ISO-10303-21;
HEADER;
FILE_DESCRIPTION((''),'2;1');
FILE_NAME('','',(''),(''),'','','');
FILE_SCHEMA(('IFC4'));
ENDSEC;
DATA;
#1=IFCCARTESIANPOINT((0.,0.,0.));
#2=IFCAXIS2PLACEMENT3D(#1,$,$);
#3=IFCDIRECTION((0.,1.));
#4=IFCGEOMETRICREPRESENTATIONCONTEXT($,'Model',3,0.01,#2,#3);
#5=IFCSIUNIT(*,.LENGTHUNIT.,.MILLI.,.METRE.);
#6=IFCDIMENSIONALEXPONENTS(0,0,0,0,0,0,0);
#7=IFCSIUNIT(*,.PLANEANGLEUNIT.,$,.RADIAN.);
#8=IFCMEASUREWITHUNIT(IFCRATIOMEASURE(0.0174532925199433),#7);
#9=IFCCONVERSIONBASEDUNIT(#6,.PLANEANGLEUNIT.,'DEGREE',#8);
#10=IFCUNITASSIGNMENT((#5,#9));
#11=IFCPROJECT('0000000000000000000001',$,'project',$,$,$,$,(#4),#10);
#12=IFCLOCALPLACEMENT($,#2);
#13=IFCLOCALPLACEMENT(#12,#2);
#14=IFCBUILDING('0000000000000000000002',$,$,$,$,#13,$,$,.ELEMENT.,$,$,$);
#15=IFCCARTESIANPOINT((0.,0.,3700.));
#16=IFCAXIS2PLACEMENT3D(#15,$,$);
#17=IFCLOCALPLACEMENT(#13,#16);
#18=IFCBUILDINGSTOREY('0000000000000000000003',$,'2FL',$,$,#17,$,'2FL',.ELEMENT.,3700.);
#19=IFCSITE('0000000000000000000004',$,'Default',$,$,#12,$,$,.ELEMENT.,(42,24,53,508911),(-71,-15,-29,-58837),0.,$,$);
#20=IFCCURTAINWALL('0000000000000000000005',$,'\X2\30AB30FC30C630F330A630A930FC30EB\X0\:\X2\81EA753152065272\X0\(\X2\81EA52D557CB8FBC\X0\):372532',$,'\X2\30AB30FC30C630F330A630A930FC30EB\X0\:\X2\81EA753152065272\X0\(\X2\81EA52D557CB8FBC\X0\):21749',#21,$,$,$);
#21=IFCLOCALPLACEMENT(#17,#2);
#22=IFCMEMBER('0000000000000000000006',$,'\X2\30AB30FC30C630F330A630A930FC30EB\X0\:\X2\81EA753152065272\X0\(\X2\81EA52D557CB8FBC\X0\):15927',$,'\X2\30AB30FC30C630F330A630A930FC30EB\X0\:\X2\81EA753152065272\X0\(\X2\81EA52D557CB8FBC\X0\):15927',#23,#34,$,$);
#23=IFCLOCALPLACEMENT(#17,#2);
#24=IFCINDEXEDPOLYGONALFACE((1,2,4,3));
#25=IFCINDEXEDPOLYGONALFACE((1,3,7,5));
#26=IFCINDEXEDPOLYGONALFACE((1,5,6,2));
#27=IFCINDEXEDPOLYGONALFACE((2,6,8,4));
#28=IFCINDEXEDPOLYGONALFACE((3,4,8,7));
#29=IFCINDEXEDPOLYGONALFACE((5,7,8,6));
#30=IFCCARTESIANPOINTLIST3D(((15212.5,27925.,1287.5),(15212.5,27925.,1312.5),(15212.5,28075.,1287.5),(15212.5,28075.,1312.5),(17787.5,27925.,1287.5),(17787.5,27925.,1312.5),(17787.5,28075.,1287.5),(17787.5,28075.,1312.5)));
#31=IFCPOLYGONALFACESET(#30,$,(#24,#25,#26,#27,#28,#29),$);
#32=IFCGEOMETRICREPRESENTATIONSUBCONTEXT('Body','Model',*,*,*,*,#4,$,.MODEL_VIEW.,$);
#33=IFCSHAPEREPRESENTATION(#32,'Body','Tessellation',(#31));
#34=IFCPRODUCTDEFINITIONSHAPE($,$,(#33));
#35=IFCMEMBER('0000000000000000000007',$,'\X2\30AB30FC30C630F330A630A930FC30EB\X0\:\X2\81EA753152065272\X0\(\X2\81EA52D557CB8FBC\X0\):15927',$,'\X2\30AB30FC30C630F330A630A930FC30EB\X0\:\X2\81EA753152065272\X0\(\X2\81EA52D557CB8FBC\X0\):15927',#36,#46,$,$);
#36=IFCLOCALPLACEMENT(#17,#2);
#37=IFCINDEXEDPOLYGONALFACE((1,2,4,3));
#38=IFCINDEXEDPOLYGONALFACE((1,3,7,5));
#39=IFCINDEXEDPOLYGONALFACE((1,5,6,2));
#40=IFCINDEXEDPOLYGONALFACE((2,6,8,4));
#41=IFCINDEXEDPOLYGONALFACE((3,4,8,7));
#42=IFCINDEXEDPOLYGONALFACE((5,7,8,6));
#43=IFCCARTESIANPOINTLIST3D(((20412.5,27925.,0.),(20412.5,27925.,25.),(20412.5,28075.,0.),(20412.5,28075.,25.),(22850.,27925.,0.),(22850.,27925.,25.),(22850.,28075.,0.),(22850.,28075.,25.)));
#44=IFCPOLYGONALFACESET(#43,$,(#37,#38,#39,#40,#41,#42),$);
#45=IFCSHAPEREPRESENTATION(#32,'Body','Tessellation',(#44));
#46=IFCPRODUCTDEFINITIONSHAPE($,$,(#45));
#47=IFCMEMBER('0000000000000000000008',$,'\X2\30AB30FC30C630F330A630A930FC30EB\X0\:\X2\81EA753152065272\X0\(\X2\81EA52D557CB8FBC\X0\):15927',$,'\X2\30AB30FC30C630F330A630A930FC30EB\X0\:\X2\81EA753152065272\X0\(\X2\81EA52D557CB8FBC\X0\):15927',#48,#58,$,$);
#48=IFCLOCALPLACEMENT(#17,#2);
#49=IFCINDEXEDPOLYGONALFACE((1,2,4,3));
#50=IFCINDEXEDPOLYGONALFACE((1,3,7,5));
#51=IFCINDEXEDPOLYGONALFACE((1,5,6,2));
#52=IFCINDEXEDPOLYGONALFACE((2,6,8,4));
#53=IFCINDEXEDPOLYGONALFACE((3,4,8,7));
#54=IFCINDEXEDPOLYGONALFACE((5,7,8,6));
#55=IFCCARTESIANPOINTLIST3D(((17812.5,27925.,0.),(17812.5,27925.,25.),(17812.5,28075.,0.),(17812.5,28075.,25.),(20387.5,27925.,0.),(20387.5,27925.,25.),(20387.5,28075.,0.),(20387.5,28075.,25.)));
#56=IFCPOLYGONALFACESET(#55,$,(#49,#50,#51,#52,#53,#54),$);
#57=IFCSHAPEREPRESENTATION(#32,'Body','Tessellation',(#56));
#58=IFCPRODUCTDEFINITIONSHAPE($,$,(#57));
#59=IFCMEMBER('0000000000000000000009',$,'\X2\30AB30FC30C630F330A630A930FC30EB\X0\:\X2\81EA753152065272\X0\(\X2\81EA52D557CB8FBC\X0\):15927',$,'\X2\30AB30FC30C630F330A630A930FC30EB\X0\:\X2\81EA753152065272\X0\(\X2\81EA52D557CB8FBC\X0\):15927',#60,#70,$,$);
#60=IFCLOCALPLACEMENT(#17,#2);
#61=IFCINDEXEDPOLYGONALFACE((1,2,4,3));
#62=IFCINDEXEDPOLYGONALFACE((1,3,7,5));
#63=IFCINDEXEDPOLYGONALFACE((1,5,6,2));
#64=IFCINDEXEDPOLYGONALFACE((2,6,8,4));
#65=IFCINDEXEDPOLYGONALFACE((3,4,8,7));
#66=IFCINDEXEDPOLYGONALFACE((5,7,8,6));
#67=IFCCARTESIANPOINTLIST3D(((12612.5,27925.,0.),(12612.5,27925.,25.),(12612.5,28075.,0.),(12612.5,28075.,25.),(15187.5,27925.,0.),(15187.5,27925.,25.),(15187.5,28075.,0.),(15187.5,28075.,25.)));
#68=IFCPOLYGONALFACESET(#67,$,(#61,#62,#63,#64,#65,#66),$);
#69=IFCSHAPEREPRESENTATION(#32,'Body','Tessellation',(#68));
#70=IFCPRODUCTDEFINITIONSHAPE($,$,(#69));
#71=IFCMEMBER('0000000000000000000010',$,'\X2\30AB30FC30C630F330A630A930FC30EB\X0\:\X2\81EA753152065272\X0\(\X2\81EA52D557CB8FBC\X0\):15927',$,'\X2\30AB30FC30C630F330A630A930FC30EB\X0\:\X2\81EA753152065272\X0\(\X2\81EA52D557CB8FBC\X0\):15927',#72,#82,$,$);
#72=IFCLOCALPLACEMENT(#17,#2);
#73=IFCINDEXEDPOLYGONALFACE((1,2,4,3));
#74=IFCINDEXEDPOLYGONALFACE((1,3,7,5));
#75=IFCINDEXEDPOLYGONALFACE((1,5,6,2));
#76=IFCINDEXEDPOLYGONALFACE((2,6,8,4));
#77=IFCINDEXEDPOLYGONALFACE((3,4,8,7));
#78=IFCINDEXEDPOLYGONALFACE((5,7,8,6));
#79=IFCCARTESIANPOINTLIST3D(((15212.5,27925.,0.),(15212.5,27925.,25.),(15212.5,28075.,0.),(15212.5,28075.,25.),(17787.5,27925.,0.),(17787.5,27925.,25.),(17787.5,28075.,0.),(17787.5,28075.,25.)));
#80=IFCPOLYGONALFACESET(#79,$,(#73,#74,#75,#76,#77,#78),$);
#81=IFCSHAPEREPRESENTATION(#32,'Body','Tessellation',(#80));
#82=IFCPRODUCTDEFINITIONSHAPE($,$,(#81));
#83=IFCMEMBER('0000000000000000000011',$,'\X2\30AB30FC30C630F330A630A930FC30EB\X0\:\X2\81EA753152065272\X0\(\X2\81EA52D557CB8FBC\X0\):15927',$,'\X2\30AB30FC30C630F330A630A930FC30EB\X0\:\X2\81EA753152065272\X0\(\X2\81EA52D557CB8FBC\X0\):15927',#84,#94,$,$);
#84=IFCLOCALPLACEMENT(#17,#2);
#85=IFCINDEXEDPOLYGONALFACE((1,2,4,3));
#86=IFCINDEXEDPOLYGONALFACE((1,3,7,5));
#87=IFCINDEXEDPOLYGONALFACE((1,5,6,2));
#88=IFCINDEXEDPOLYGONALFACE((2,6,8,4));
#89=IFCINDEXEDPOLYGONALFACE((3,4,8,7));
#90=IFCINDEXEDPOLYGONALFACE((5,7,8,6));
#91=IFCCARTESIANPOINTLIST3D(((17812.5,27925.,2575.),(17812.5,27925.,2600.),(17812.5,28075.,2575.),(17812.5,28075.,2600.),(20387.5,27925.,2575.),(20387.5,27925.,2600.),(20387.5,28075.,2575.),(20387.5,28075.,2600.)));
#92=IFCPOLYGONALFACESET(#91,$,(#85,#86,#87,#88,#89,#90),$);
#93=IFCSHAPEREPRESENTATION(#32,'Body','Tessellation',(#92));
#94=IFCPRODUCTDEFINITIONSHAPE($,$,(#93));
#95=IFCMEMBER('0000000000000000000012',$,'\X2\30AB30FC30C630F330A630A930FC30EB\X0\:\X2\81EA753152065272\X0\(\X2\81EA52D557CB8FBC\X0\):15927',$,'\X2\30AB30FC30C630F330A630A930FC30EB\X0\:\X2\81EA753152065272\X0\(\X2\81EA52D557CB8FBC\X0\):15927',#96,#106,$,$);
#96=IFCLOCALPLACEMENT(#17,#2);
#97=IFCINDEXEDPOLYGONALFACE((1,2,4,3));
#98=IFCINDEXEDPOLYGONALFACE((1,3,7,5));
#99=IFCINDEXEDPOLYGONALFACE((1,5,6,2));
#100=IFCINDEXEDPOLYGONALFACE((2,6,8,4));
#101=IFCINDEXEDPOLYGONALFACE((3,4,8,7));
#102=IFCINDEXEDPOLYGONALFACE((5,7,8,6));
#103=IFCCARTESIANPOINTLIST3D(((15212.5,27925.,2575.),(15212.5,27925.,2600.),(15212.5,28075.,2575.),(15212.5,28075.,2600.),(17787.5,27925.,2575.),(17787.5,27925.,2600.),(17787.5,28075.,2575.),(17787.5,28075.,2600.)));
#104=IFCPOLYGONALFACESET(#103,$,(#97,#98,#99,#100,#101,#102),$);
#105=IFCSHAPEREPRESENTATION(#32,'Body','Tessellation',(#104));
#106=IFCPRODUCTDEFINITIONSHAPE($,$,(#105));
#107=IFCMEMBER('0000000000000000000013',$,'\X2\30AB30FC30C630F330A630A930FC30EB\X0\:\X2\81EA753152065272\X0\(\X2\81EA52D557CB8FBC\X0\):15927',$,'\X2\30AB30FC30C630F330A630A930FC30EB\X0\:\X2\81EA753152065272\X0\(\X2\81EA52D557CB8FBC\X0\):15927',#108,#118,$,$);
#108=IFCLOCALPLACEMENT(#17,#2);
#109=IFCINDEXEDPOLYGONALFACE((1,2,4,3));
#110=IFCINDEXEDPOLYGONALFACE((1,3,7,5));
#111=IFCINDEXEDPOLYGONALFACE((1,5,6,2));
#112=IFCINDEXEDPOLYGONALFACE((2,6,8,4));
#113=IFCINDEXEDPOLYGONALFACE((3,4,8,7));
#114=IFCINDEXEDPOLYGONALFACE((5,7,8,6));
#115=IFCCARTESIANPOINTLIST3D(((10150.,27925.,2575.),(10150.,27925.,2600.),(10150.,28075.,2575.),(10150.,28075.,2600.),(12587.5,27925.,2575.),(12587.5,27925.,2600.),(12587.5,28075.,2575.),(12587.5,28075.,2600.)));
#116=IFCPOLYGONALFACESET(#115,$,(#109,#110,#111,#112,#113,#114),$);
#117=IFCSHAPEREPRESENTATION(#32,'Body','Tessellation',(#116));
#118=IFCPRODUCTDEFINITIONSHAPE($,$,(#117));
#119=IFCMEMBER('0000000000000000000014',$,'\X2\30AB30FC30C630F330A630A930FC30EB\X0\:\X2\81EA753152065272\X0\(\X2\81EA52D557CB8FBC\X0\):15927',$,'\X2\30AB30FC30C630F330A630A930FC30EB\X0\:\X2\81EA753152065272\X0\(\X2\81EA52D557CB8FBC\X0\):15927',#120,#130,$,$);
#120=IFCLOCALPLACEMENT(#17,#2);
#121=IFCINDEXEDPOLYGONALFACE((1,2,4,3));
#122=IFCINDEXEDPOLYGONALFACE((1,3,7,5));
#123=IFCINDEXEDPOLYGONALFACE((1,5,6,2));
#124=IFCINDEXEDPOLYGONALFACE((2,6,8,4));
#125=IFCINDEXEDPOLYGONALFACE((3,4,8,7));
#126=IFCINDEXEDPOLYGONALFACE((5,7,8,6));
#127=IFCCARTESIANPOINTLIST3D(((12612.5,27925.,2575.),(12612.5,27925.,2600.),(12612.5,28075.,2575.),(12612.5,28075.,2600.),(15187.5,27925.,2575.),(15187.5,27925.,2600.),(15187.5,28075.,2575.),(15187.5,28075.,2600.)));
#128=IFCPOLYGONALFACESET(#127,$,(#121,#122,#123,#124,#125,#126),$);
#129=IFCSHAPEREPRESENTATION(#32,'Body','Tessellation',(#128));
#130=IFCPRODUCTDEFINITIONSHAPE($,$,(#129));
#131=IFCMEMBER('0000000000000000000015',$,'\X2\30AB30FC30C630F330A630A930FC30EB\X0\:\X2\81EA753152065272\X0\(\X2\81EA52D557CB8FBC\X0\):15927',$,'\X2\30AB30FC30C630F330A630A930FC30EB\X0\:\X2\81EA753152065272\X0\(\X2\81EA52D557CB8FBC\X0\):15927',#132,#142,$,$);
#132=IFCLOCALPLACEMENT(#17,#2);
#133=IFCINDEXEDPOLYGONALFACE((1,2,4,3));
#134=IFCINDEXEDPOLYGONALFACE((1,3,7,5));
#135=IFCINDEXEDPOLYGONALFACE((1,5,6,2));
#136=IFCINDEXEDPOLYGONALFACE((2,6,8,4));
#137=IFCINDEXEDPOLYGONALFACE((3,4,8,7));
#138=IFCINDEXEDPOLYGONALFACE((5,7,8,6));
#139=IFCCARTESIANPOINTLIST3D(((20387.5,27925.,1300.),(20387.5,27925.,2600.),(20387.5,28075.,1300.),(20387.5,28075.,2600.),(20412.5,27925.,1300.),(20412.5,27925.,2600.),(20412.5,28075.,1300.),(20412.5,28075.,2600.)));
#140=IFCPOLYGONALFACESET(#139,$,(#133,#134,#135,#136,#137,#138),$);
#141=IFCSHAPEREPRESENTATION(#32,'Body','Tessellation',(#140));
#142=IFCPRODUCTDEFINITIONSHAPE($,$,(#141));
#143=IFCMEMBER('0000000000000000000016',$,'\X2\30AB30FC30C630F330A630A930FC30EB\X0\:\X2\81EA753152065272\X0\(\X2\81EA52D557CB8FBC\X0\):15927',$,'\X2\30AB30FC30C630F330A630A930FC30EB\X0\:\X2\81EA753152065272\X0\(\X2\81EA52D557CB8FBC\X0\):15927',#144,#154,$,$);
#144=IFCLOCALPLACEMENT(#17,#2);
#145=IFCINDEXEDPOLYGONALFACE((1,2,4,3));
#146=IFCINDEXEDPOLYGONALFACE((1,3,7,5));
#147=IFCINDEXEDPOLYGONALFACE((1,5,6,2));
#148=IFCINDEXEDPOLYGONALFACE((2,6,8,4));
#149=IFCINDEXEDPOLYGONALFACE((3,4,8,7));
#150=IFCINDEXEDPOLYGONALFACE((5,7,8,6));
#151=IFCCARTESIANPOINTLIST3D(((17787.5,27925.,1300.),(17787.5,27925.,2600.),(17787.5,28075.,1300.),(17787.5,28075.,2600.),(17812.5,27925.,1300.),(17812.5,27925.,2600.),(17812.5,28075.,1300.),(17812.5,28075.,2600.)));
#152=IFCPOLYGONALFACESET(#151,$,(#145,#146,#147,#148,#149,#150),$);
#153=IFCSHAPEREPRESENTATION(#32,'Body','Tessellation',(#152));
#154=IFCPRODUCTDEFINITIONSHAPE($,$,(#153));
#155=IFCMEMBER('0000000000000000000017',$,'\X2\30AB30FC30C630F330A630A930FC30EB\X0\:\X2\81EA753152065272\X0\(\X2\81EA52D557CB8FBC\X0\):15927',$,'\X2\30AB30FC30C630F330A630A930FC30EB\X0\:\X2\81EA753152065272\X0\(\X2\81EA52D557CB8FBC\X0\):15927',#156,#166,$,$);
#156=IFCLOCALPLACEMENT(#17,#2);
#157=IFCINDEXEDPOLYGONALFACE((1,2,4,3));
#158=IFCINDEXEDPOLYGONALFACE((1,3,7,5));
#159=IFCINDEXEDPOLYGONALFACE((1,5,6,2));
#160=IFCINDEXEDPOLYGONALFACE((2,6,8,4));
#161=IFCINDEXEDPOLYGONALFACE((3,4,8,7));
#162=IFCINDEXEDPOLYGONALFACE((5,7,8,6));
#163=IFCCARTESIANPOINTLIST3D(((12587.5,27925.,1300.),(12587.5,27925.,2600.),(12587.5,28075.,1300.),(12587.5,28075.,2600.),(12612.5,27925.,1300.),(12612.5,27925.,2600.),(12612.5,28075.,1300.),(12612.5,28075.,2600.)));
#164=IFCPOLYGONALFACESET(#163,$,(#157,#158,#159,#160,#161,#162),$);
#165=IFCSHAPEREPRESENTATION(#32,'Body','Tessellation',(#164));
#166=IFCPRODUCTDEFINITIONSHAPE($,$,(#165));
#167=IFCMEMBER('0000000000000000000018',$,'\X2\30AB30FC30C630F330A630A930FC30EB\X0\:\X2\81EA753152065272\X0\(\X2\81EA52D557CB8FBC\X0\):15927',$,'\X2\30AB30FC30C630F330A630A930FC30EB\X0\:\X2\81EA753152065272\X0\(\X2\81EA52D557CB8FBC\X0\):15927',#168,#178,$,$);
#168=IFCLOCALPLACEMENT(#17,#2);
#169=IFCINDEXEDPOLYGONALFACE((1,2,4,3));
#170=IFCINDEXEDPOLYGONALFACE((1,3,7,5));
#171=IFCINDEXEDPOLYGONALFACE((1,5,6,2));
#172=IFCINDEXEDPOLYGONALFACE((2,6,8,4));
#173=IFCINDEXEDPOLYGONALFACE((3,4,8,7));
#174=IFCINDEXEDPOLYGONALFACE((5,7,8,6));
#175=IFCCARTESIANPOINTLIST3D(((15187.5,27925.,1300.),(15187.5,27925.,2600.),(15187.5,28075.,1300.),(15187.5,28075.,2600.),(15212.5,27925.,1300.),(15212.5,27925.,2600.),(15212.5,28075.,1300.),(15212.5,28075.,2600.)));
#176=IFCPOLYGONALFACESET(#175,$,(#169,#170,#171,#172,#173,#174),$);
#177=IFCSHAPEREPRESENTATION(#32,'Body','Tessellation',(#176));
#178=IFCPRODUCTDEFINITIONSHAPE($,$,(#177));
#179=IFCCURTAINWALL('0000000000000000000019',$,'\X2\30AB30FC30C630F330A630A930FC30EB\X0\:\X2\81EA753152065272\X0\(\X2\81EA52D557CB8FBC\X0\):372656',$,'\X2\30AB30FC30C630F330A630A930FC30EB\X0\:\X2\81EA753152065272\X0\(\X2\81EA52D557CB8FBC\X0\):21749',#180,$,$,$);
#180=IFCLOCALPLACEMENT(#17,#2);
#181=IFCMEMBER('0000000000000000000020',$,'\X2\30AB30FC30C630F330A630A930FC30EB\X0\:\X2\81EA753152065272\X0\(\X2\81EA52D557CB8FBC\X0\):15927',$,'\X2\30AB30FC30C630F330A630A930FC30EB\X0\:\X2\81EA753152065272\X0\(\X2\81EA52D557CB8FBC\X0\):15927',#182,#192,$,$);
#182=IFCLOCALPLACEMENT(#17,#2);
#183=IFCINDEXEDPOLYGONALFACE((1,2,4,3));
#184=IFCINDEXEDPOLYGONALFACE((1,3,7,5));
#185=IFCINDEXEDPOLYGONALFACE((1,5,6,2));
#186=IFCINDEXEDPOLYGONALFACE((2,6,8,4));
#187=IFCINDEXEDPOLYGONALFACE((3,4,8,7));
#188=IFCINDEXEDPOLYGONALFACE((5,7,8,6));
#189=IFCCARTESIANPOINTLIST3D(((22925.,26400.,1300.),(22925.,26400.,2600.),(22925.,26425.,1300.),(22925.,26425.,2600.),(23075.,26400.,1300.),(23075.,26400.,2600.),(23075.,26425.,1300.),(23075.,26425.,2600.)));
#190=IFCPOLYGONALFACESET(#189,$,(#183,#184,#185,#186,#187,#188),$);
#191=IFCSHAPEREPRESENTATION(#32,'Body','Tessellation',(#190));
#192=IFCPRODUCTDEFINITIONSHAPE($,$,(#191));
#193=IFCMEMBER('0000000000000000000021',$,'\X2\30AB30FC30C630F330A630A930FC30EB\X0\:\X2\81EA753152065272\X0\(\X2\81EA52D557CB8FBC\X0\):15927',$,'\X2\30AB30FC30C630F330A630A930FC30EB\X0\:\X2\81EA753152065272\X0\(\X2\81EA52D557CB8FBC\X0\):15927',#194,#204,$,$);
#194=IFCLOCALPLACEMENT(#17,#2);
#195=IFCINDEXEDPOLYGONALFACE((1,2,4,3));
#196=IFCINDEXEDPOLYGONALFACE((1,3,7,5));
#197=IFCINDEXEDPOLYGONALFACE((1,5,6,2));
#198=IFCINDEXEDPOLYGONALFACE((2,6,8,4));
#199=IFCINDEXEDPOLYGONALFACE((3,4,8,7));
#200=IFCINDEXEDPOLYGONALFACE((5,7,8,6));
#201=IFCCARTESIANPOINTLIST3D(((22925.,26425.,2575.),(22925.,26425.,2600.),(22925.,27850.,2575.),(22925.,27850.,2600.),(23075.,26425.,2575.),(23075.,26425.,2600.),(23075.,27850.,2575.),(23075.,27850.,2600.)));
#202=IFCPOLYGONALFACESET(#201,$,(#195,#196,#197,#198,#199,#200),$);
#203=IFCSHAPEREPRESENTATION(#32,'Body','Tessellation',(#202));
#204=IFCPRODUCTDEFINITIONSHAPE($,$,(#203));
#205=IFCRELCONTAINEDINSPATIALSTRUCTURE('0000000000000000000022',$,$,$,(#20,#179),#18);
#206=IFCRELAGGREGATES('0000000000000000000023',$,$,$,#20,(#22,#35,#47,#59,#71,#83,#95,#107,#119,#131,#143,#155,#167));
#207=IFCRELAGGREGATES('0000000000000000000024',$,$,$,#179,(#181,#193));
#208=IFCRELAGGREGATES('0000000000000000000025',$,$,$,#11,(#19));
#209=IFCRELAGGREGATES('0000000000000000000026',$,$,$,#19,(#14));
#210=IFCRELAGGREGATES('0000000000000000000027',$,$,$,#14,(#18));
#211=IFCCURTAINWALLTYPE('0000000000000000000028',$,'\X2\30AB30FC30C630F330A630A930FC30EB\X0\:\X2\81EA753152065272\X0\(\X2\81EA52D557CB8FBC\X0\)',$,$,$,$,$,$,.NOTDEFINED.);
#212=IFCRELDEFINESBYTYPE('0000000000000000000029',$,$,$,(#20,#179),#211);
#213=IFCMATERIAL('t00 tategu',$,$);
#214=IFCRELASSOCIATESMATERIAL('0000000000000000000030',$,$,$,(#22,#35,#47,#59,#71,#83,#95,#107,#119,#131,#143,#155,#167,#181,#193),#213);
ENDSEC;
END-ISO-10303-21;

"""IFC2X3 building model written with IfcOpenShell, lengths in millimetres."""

from ifc_helpers import new_model, entity, si_unit, converted_unit, direction, frame, frame_2d, origin, origin_2d_with_axis, place, context, subcontext, project, spatial, rectangle, extrude, material, type_object, element, aggregate, save


model = new_model("IFC2X3")

# Units and contexts
model_context = context("Model", 3, precision=0.01, world=origin(), true_north=direction((0.0, 1.0)))
body_context = subcontext(model_context, "Body", "Model", "MODEL_VIEW")
ifc_project = project(units=[si_unit("LENGTHUNIT", "METRE", prefix="MILLI"), converted_unit("PLANEANGLEUNIT", "DEGREE", entity("IfcRatioMeasure", 0.0174532925199433), si_unit("PLANEANGLEUNIT", "RADIAN"), dimensions=[0, 0, 0, 0, 0, 0, 0])], contexts=[model_context])

# Site, building, storey
site_placement = place(None, origin())
site = spatial("IfcSite", under=ifc_project, at=site_placement, Name="Default", CompositionType="ELEMENT", RefLatitude=(42, 24, 53, 508911), RefLongitude=(-71, -15, -29, -58837), RefElevation=0.0)
building_placement = place(site_placement, origin())
building = spatial("IfcBuilding", under=site, at=building_placement, CompositionType="ELEMENT")
storey_placement = place(building_placement, frame((0.0, 0.0, 3700.0)))
storey = spatial("IfcBuildingStorey", under=building, at=storey_placement, Name="2FL", LongName="2FL", CompositionType="ELEMENT", Elevation=3700.0)

# Curtain walls, members
curtain_wall_type = type_object("IfcCurtainWallType", Name="カーテンウォール:自由分割(自動埋込)", PredefinedType="NOTDEFINED")
curtain_wall_1_placement = place(storey_placement, frame((0.0, 0.0, -3700.0)))
curtain_wall_1 = element("IfcCurtainWall", 1, at=curtain_wall_1_placement, inside=storey, type_object=curtain_wall_type, Name="カーテンウォール:自由分割(自動埋込):372532", ObjectType="カーテンウォール:自由分割(自動埋込):21749")
ifc_material = material(Name="t00 tategu")
member_1_placement = place(curtain_wall_1_placement, frame((0.0, 0.0, 3700.0)))
member_1 = element("IfcMember", 2, at=member_1_placement, material=ifc_material, Name="カーテンウォール:自由分割(自動埋込):15927", ObjectType="カーテンウォール:自由分割(自動埋込):15927", context=body_context, shape_type="SweptSolid", body=[
    extrude(rectangle(XDim=25.0, YDim=150.0, at=frame_2d((0.0, 0.0), x_axis=(1.0, 0.0))), frame((17787.5, 28000.0, 1300.0), z_axis=(-1.0, 0.0, 0.0), x_axis=(0.0, 0.0, -1.0)), (0.0, 0.0, 1.0), 2575.0),
])
member_2_placement = place(curtain_wall_1_placement, frame((0.0, 0.0, 3700.0)))
member_2 = element("IfcMember", 3, at=member_2_placement, material=ifc_material, Name="カーテンウォール:自由分割(自動埋込):15927", ObjectType="カーテンウォール:自由分割(自動埋込):15927", context=body_context, shape_type="SweptSolid", body=[
    extrude(rectangle(XDim=25.0, YDim=150.0, at=frame_2d((0.0, 0.0), x_axis=(1.0, 0.0))), frame((20412.5, 28000.0, 12.5), z_axis=(1.0, 0.0, 0.0), x_axis=(0.0, 0.0, -1.0)), (0.0, 0.0, 1.0), 2437.5),
])
member_3_placement = place(curtain_wall_1_placement, frame((0.0, 0.0, 3700.0)))
member_3 = element("IfcMember", 4, at=member_3_placement, material=ifc_material, Name="カーテンウォール:自由分割(自動埋込):15927", ObjectType="カーテンウォール:自由分割(自動埋込):15927", context=body_context, shape_type="SweptSolid", body=[
    extrude(rectangle(XDim=25.0, YDim=150.0, at=frame_2d((0.0, 0.0), x_axis=(1.0, 0.0))), frame((17812.5, 28000.0, 12.5), z_axis=(1.0, 0.0, 0.0), x_axis=(0.0, 0.0, -1.0)), (0.0, 0.0, 1.0), 2575.0),
])
member_4_placement = place(curtain_wall_1_placement, frame((0.0, 0.0, 3700.0)))
member_4 = element("IfcMember", 5, at=member_4_placement, material=ifc_material, Name="カーテンウォール:自由分割(自動埋込):15927", ObjectType="カーテンウォール:自由分割(自動埋込):15927", context=body_context, shape_type="SweptSolid", body=[
    extrude(rectangle(XDim=25.0, YDim=150.0, at=frame_2d((0.0, 0.0), x_axis=(1.0, 0.0))), frame((12612.5, 28000.0, 12.5), z_axis=(1.0, 0.0, 0.0), x_axis=(0.0, 0.0, -1.0)), (0.0, 0.0, 1.0), 2575.0),
])
member_5_placement = place(curtain_wall_1_placement, frame((0.0, 0.0, 3700.0)))
member_5 = element("IfcMember", 6, at=member_5_placement, material=ifc_material, Name="カーテンウォール:自由分割(自動埋込):15927", ObjectType="カーテンウォール:自由分割(自動埋込):15927", context=body_context, shape_type="SweptSolid", body=[
    extrude(rectangle(XDim=25.0, YDim=150.0, at=frame_2d((0.0, 0.0), x_axis=(1.0, 0.0))), frame((15212.5, 28000.0, 12.5), z_axis=(1.0, 0.0, 0.0), x_axis=(0.0, 0.0, -1.0)), (0.0, 0.0, 1.0), 2575.0),
])
member_6_placement = place(curtain_wall_1_placement, frame((0.0, 0.0, 3700.0)))
member_6 = element("IfcMember", 7, at=member_6_placement, material=ifc_material, Name="カーテンウォール:自由分割(自動埋込):15927", ObjectType="カーテンウォール:自由分割(自動埋込):15927", context=body_context, shape_type="SweptSolid", body=[
    extrude(rectangle(XDim=25.0, YDim=150.0, at=frame_2d((0.0, 0.0), x_axis=(1.0, 0.0))), frame((20387.5, 28000.0, 2587.5), z_axis=(-1.0, 0.0, 0.0), x_axis=(0.0, 0.0, -1.0)), (0.0, 0.0, 1.0), 2575.0),
])
member_7_placement = place(curtain_wall_1_placement, frame((0.0, 0.0, 3700.0)))
member_7 = element("IfcMember", 8, at=member_7_placement, material=ifc_material, Name="カーテンウォール:自由分割(自動埋込):15927", ObjectType="カーテンウォール:自由分割(自動埋込):15927", context=body_context, shape_type="SweptSolid", body=[
    extrude(rectangle(XDim=25.0, YDim=150.0, at=frame_2d((0.0, 0.0), x_axis=(1.0, 0.0))), frame((17787.5, 28000.0, 2587.5), z_axis=(-1.0, 0.0, 0.0), x_axis=(0.0, 0.0, -1.0)), (0.0, 0.0, 1.0), 2575.0),
])
member_8_placement = place(curtain_wall_1_placement, frame((0.0, 0.0, 3700.0)))
member_8 = element("IfcMember", 9, at=member_8_placement, material=ifc_material, Name="カーテンウォール:自由分割(自動埋込):15927", ObjectType="カーテンウォール:自由分割(自動埋込):15927", context=body_context, shape_type="SweptSolid", body=[
    extrude(rectangle(XDim=25.0, YDim=150.0, at=frame_2d((0.0, 0.0), x_axis=(1.0, 0.0))), frame((12587.5, 28000.0, 2587.5), z_axis=(-1.0, 0.0, 0.0), x_axis=(0.0, 0.0, -1.0)), (0.0, 0.0, 1.0), 2437.5),
])
member_9_placement = place(curtain_wall_1_placement, frame((0.0, 0.0, 3700.0)))
member_9 = element("IfcMember", 10, at=member_9_placement, material=ifc_material, Name="カーテンウォール:自由分割(自動埋込):15927", ObjectType="カーテンウォール:自由分割(自動埋込):15927", context=body_context, shape_type="SweptSolid", body=[
    extrude(rectangle(XDim=25.0, YDim=150.0, at=frame_2d((0.0, 0.0), x_axis=(1.0, 0.0))), frame((15187.5, 28000.0, 2587.5), z_axis=(-1.0, 0.0, 0.0), x_axis=(0.0, 0.0, -1.0)), (0.0, 0.0, 1.0), 2575.0),
])
member_10_placement = place(curtain_wall_1_placement, frame((0.0, 0.0, 3700.0)))
member_10 = element("IfcMember", 11, at=member_10_placement, material=ifc_material, Name="カーテンウォール:自由分割(自動埋込):15927", ObjectType="カーテンウォール:自由分割(自動埋込):15927", context=body_context, shape_type="SweptSolid", body=[
    extrude(rectangle(XDim=25.0, YDim=150.0, at=origin_2d_with_axis()), frame((20400.0, 28000.0, 1300.0), z_axis=(0.0, 0.0, 1.0), x_axis=(-1.0, 0.0, 0.0)), (0.0, 0.0, 1.0), 1300.0),
])
member_11_placement = place(curtain_wall_1_placement, frame((0.0, 0.0, 3700.0)))
member_11 = element("IfcMember", 12, at=member_11_placement, material=ifc_material, Name="カーテンウォール:自由分割(自動埋込):15927", ObjectType="カーテンウォール:自由分割(自動埋込):15927", context=body_context, shape_type="SweptSolid", body=[
    extrude(rectangle(XDim=25.0, YDim=150.0, at=origin_2d_with_axis()), frame((17800.0, 28000.0, 1300.0), z_axis=(0.0, 0.0, 1.0), x_axis=(-1.0, 0.0, 0.0)), (0.0, 0.0, 1.0), 1300.0),
])
member_12_placement = place(curtain_wall_1_placement, frame((0.0, 0.0, 3700.0)))
member_12 = element("IfcMember", 13, at=member_12_placement, material=ifc_material, Name="カーテンウォール:自由分割(自動埋込):15927", ObjectType="カーテンウォール:自由分割(自動埋込):15927", context=body_context, shape_type="SweptSolid", body=[
    extrude(rectangle(XDim=25.0, YDim=150.0, at=origin_2d_with_axis()), frame((12600.0, 28000.0, 1300.0), z_axis=(0.0, 0.0, 1.0), x_axis=(-1.0, 0.0, 0.0)), (0.0, 0.0, 1.0), 1300.0),
])
member_13_placement = place(curtain_wall_1_placement, frame((0.0, 0.0, 3700.0)))
member_13 = element("IfcMember", 14, at=member_13_placement, material=ifc_material, Name="カーテンウォール:自由分割(自動埋込):15927", ObjectType="カーテンウォール:自由分割(自動埋込):15927", context=body_context, shape_type="SweptSolid", body=[
    extrude(rectangle(XDim=25.0, YDim=150.0, at=frame_2d((0.0, 0.0), x_axis=(1.0, 0.0))), frame((15200.0, 28000.0, 1300.0), z_axis=(0.0, 0.0, 1.0), x_axis=(-1.0, 0.0, 0.0)), (0.0, 0.0, 1.0), 1300.0),
])
aggregate(curtain_wall_1, [member_1, member_2, member_3, member_4, member_5, member_6, member_7, member_8, member_9, member_10, member_11, member_12, member_13])
curtain_wall_2_placement = place(storey_placement, frame((0.0, 0.0, -3700.0)))
curtain_wall_2 = element("IfcCurtainWall", 15, at=curtain_wall_2_placement, inside=storey, type_object=curtain_wall_type, Name="カーテンウォール:自由分割(自動埋込):372656", ObjectType="カーテンウォール:自由分割(自動埋込):21749")
member_14_placement = place(curtain_wall_2_placement, frame((0.0, 0.0, 3700.0)))
member_14 = element("IfcMember", 16, at=member_14_placement, material=ifc_material, Name="カーテンウォール:自由分割(自動埋込):15927", ObjectType="カーテンウォール:自由分割(自動埋込):15927", context=body_context, shape_type="SweptSolid", body=[
    extrude(rectangle(XDim=150.0, YDim=25.0, at=frame_2d((0.0, 0.0), x_axis=(1.0, 0.0))), frame((23000.0, 26412.5, 2600.0), z_axis=(0.0, 0.0, -1.0), x_axis=(-1.0, 0.0, 0.0)), (0.0, 0.0, 1.0), 1300.0),
])
member_15_placement = place(curtain_wall_2_placement, frame((0.0, 0.0, 3700.0)))
member_15 = element("IfcMember", 17, at=member_15_placement, material=ifc_material, Name="カーテンウォール:自由分割(自動埋込):15927", ObjectType="カーテンウォール:自由分割(自動埋込):15927", context=body_context, shape_type="SweptSolid", body=[
    extrude(rectangle(XDim=25.0, YDim=150.0, at=frame_2d((0.0, 0.0), x_axis=(1.0, 0.0))), frame((23000.0, 27850.0, 2587.5), z_axis=(0.0, -1.0, 0.0), x_axis=(0.0, 0.0, -1.0)), (0.0, 0.0, 1.0), 1425.0),
])
aggregate(curtain_wall_2, [member_14, member_15])

save(model, "model.ifc")
